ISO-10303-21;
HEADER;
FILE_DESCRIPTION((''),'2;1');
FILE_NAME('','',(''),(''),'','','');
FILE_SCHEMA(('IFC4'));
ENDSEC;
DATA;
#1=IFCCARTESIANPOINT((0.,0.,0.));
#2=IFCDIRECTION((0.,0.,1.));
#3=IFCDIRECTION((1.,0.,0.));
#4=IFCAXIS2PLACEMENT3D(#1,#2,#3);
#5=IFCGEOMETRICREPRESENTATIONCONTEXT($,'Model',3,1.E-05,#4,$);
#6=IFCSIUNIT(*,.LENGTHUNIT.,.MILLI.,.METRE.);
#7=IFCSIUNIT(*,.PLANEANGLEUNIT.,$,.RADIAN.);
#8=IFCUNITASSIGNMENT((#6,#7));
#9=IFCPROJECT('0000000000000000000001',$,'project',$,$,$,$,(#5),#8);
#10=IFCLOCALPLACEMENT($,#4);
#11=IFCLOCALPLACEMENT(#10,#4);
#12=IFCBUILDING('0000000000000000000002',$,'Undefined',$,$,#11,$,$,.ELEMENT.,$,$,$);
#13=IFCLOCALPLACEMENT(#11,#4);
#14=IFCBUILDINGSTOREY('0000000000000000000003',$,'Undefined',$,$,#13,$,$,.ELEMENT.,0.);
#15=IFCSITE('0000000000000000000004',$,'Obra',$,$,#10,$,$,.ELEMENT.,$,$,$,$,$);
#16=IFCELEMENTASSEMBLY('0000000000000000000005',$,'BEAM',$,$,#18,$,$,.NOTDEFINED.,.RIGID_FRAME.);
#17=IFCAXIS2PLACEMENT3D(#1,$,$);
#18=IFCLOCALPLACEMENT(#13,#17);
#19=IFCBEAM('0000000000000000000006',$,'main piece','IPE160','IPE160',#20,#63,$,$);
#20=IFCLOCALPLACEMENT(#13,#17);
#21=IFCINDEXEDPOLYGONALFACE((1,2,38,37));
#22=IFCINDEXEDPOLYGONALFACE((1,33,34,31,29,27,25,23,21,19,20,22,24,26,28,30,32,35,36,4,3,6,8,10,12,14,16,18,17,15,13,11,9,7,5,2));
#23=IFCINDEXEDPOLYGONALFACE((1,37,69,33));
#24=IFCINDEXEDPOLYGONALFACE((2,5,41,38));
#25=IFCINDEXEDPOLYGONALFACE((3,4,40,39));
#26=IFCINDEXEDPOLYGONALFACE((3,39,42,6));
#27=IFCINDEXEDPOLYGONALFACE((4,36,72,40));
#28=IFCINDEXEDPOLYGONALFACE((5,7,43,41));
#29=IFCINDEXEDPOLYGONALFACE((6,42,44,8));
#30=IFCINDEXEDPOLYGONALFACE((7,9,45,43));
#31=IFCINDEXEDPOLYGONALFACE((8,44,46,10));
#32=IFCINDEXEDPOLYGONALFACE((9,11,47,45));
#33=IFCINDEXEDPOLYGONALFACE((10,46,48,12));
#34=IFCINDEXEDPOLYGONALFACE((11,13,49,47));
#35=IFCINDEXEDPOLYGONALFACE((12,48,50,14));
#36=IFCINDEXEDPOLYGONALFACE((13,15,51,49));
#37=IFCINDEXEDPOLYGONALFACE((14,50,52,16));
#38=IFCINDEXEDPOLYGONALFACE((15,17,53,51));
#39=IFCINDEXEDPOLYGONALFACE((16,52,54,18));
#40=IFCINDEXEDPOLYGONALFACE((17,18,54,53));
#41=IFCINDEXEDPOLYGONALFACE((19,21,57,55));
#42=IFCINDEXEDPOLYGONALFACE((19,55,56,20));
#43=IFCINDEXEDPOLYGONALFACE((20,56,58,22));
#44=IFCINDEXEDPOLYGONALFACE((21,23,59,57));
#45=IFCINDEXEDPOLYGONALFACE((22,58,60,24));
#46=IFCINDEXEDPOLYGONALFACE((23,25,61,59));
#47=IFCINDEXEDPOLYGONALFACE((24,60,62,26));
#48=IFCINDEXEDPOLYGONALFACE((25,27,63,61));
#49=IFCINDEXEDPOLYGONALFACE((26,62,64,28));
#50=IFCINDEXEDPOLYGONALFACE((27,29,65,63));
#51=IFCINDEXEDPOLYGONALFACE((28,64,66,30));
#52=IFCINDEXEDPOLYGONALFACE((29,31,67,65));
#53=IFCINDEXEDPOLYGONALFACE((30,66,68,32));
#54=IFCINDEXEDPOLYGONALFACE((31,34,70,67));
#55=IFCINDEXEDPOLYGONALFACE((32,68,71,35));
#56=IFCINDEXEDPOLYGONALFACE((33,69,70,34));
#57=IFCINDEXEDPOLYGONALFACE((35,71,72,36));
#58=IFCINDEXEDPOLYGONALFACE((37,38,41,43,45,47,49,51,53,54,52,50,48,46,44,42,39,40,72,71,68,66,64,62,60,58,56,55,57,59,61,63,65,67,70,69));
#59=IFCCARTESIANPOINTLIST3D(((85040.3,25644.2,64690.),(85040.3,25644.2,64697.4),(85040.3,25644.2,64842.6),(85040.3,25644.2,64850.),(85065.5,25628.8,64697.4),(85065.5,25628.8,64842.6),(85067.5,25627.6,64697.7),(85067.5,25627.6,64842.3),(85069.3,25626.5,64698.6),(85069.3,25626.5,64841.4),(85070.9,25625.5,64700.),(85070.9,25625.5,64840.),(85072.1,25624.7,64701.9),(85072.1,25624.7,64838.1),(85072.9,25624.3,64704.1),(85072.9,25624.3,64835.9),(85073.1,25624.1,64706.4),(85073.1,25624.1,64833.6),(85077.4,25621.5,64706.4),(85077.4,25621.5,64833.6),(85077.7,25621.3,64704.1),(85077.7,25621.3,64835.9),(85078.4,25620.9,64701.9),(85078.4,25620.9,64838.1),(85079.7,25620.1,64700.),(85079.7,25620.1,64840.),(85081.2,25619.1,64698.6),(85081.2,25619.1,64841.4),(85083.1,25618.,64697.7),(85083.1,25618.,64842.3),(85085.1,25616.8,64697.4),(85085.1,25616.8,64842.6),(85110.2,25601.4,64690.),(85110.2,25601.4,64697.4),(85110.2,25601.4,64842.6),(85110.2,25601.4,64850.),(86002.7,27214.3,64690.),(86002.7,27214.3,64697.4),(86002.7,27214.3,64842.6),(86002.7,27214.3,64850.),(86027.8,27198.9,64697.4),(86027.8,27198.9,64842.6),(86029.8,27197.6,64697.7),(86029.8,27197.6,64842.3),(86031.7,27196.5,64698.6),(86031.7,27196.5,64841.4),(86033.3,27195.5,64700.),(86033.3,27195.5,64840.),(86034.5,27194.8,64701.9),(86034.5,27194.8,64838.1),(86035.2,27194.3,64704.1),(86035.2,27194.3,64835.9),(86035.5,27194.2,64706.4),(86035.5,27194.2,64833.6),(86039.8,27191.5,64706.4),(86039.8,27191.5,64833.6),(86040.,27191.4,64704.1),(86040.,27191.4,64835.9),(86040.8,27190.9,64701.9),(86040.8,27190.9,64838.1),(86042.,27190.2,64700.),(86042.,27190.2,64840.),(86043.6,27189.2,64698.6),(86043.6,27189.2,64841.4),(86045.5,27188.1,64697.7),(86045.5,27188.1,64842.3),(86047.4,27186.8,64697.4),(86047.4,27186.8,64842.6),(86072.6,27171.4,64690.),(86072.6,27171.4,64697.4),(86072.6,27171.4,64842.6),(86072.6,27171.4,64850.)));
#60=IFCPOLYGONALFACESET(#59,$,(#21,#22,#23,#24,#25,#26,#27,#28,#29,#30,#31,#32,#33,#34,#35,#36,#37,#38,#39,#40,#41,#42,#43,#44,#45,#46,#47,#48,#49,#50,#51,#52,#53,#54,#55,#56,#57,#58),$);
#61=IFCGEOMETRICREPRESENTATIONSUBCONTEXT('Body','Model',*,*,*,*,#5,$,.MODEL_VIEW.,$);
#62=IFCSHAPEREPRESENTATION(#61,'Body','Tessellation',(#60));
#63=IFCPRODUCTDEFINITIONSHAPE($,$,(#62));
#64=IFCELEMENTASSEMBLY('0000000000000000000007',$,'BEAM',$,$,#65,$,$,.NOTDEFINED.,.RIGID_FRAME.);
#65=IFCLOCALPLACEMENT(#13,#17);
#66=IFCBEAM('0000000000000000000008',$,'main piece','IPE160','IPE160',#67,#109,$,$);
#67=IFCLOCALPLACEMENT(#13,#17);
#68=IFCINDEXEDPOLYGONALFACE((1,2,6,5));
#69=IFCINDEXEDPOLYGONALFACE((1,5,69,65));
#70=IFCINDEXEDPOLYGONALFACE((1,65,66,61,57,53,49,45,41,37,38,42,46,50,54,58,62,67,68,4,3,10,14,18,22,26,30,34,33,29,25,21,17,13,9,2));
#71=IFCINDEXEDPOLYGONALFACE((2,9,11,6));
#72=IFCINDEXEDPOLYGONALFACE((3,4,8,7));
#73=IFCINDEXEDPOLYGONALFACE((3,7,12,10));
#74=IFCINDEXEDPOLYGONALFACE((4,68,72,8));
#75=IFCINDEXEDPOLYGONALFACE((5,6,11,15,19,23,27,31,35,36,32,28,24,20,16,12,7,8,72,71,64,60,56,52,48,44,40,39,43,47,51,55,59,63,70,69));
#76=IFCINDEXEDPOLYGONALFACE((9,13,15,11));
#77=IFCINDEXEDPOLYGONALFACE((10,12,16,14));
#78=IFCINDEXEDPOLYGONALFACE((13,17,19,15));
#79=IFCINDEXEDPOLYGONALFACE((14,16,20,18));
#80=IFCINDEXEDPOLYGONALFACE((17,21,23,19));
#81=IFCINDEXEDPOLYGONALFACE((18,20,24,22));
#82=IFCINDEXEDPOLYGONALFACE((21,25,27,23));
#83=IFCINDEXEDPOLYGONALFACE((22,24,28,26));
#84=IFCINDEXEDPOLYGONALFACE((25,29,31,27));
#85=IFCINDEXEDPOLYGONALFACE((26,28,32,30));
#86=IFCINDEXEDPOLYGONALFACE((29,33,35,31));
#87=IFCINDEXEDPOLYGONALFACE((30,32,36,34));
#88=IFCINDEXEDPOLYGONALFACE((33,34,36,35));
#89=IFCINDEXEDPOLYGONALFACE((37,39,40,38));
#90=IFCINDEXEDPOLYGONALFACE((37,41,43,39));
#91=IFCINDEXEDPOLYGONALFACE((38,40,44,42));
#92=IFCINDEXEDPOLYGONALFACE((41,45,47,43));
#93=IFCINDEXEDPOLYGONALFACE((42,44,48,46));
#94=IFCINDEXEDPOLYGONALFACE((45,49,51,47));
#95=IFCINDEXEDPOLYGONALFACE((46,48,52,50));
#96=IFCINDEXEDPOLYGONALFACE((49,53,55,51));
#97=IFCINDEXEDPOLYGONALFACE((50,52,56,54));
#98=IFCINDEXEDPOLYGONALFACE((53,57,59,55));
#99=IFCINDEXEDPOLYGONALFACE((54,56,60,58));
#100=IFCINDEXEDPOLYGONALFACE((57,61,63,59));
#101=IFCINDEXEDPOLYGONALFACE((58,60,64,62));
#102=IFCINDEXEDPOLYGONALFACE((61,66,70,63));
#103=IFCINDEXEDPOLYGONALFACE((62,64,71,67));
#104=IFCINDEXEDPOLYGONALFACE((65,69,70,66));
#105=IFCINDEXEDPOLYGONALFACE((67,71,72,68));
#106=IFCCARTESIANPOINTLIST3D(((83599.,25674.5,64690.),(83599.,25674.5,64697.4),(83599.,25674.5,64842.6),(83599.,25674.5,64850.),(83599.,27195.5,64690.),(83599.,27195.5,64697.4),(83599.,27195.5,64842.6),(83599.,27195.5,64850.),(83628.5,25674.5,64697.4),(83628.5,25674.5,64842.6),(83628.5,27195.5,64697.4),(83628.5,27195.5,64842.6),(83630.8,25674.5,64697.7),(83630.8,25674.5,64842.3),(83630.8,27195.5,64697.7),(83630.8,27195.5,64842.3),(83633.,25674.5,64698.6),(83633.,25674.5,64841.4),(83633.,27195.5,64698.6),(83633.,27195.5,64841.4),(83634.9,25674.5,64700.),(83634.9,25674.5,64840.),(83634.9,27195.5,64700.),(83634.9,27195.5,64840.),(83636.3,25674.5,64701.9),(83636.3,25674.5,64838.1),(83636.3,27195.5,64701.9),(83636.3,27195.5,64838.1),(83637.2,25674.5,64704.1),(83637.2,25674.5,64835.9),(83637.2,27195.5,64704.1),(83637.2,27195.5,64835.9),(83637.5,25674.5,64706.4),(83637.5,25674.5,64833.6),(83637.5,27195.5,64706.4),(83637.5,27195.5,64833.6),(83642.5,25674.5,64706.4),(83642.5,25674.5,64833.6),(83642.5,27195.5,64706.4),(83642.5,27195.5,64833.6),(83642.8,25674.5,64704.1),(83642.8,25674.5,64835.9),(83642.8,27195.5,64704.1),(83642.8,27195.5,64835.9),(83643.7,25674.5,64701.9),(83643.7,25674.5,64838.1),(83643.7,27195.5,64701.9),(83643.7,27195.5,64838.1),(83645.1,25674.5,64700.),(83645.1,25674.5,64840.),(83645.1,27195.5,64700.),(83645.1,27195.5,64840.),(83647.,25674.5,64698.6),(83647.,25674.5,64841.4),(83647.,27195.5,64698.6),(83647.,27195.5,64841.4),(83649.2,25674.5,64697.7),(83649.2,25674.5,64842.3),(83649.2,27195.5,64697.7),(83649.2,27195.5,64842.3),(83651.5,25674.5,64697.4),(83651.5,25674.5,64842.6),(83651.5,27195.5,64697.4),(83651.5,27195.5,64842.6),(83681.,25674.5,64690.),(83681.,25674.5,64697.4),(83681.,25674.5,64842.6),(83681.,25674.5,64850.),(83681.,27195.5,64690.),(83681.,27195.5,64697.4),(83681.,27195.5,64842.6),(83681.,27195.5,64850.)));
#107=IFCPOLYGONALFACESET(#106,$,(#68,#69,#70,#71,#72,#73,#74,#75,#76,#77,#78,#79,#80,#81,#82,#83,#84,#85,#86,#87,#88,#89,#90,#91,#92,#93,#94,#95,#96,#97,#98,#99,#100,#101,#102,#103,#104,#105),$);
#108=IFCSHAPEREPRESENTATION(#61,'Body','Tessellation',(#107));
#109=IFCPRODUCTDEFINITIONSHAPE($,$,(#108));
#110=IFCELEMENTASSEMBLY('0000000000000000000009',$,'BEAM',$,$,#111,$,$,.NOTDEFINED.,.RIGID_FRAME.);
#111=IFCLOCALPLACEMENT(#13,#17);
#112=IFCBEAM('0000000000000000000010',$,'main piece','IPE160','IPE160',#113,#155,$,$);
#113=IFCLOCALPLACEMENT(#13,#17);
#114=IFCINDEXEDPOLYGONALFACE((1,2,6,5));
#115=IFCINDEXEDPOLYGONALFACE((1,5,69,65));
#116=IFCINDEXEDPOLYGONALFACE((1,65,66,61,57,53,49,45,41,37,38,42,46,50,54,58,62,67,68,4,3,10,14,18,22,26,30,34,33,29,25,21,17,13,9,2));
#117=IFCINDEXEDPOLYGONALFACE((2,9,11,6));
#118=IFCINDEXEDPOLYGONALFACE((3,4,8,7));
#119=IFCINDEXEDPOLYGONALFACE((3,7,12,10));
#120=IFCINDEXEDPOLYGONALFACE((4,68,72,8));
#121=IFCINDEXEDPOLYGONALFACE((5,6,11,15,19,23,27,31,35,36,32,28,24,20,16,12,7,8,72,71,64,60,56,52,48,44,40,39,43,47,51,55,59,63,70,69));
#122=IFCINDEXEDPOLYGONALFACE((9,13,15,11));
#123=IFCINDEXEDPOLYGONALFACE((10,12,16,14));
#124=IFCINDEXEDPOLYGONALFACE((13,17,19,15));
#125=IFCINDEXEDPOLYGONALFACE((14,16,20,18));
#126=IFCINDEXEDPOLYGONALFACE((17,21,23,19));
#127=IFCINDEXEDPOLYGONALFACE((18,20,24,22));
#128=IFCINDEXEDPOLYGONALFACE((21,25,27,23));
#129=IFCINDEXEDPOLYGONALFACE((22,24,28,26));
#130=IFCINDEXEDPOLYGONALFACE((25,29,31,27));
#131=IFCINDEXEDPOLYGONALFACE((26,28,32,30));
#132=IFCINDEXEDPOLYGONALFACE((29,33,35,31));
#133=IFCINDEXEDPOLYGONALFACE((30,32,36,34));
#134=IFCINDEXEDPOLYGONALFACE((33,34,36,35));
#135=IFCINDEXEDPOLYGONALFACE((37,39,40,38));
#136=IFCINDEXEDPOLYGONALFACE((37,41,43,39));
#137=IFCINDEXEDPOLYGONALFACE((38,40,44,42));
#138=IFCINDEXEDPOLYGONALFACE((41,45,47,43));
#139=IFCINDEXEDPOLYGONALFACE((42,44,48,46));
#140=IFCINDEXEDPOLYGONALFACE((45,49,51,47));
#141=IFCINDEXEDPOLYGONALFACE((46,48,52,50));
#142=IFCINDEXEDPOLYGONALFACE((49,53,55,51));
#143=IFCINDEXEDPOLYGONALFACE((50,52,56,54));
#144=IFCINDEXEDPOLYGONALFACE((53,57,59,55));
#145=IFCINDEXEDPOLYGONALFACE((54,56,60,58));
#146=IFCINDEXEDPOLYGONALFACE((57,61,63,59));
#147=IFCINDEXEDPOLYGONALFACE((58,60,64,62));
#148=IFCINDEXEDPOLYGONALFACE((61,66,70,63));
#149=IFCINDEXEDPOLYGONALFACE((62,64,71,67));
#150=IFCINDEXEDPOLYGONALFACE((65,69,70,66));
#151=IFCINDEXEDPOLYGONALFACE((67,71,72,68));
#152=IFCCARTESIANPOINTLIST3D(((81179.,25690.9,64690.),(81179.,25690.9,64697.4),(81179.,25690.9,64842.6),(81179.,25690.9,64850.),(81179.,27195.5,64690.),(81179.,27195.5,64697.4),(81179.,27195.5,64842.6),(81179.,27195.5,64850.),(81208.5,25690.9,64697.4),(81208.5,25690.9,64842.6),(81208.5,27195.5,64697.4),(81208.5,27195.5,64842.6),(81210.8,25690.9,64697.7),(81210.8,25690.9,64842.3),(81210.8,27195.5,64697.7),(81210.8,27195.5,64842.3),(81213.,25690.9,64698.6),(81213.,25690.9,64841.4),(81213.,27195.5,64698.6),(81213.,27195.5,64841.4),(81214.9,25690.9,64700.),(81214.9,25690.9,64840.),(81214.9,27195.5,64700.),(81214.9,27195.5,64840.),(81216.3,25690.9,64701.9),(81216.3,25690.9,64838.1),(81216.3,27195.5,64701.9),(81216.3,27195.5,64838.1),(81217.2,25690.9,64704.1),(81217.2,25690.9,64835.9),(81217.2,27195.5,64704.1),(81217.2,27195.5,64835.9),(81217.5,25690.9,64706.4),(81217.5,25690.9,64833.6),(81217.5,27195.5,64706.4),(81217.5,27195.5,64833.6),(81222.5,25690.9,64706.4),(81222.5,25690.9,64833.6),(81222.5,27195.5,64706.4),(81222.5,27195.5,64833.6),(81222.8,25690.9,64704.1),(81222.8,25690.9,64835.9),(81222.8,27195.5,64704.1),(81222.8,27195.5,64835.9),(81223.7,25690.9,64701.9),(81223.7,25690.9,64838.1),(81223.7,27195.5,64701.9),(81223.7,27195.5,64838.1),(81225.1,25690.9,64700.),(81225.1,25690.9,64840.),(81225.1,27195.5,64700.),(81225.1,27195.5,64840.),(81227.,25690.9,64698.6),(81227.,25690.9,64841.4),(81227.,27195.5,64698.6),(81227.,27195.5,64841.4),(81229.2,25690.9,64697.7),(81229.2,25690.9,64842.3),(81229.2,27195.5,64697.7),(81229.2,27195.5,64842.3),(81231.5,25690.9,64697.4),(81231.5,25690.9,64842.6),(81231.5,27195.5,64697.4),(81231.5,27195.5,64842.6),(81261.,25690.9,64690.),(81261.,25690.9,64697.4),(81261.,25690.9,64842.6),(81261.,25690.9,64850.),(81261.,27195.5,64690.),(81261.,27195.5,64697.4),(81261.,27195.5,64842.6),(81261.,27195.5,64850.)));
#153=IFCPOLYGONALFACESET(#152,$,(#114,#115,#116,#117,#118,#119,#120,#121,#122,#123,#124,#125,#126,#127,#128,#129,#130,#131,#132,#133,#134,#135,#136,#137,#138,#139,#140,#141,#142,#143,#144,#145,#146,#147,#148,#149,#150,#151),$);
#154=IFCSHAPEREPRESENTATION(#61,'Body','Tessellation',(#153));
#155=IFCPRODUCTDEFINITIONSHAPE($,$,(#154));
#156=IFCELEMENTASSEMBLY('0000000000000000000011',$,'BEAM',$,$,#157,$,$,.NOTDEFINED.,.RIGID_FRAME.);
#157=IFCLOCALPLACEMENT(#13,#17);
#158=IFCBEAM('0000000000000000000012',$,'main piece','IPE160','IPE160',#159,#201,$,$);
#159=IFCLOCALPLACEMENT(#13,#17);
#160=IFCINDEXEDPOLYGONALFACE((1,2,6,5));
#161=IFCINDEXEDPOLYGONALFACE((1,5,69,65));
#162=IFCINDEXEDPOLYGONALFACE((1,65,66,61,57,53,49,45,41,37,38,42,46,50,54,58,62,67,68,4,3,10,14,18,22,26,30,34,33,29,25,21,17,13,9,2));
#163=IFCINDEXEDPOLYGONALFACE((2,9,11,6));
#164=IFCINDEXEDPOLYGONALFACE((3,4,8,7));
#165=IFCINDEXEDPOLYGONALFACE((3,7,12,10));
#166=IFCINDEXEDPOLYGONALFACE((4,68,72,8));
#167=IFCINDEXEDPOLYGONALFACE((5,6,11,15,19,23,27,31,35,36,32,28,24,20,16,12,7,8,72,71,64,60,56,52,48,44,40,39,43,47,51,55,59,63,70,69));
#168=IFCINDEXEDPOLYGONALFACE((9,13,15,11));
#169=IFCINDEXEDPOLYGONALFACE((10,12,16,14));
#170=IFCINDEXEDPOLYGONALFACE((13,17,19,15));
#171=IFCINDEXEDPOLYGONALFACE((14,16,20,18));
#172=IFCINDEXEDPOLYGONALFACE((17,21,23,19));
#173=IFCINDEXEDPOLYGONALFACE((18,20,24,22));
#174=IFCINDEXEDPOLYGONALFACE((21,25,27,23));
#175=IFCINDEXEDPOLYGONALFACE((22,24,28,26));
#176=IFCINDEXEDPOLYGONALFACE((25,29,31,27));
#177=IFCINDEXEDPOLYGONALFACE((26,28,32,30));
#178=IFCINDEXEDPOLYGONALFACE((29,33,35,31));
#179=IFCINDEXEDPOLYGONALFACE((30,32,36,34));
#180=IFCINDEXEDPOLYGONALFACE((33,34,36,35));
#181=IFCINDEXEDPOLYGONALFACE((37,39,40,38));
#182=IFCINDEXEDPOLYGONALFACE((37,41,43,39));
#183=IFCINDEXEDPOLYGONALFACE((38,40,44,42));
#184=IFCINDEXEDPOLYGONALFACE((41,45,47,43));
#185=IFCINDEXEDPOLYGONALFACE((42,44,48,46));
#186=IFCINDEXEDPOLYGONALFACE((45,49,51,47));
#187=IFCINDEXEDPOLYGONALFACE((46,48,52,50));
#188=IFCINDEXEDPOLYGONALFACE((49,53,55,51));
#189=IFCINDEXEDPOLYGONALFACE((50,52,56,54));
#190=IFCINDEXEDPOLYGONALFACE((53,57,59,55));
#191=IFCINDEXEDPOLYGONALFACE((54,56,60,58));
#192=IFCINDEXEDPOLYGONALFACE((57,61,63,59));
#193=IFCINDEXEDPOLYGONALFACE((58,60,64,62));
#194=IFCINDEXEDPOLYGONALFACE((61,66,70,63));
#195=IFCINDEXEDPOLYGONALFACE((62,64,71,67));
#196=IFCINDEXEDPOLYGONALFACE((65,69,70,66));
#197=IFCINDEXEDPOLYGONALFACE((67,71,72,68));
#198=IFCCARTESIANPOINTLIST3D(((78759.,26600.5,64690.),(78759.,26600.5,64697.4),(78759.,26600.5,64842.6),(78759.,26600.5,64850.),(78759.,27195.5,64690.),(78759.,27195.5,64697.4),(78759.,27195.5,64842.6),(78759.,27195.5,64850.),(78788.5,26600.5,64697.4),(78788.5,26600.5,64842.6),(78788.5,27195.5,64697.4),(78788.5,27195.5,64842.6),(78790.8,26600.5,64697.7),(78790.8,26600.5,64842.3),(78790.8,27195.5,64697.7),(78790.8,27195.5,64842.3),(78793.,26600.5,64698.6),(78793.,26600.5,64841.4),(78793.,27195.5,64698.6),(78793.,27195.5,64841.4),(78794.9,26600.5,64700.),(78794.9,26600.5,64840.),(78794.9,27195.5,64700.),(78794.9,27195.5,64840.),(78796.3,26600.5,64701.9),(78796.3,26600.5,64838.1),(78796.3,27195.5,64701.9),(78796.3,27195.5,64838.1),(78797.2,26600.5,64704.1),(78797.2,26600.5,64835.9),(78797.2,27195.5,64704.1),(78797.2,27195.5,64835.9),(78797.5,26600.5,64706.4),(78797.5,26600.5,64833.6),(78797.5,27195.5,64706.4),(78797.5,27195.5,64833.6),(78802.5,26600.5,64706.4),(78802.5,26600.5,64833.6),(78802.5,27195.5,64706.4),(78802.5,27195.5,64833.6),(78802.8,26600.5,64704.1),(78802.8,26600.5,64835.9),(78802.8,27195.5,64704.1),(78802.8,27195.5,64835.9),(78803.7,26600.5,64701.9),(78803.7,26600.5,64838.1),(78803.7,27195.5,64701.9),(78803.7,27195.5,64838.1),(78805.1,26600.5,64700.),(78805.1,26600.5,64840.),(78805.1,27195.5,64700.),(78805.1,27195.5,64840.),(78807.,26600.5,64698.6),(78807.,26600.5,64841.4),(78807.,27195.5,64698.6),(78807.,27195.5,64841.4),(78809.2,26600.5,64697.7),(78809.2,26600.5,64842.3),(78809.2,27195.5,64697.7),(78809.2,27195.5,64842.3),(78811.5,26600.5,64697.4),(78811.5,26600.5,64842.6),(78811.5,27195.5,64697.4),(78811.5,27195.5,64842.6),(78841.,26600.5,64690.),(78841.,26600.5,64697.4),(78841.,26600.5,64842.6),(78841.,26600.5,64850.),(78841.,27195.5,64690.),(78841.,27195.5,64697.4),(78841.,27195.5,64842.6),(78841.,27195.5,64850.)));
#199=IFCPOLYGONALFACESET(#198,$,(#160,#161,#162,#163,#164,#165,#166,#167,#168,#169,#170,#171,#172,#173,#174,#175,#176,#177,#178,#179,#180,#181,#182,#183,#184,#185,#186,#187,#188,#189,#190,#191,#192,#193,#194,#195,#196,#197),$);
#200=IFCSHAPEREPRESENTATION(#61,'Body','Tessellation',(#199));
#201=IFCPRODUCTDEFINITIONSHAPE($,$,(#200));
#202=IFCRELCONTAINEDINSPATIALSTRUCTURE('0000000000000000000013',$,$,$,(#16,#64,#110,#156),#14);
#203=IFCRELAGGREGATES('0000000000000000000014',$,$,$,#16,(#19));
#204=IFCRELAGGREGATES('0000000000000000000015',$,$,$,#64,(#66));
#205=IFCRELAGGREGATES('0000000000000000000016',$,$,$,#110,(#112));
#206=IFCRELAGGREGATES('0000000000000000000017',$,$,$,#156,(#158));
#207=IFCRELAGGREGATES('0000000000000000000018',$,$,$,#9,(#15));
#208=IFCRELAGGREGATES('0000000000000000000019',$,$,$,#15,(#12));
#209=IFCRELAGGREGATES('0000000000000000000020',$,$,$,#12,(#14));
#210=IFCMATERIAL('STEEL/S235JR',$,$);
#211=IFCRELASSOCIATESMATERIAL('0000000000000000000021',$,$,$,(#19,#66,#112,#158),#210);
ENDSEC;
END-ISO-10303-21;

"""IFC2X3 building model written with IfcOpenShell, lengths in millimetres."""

from ifc_helpers import new_model, si_unit, frame, origin_with_axes, origin_2d_with_axis, place, context, subcontext, project, spatial, i_section, extrude, material, element, aggregate, save


model = new_model("IFC2X3")

# Units and contexts
model_context = context("Model", 3, precision=1e-05, world=origin_with_axes())
body_context = subcontext(model_context, "Body", "Model", "MODEL_VIEW")
ifc_project = project(units=[si_unit("LENGTHUNIT", "METRE", prefix="MILLI"), si_unit("PLANEANGLEUNIT", "RADIAN")], contexts=[model_context])

# Site, building, storey
site_placement = place(None, origin_with_axes())
site = spatial("IfcSite", under=ifc_project, at=site_placement, Name="Obra", CompositionType="ELEMENT")
building_placement = place(site_placement, origin_with_axes())
building = spatial("IfcBuilding", under=site, at=building_placement, Name="Undefined", CompositionType="ELEMENT")
storey_placement = place(building_placement, origin_with_axes())
storey = spatial("IfcBuildingStorey", under=building, at=storey_placement, Name="Undefined", CompositionType="ELEMENT", Elevation=0.0)

# Element assemblies, beams
assembly_1_placement = place(storey_placement, origin_with_axes())
assembly_1 = element("IfcElementAssembly", 1, at=assembly_1_placement, inside=storey, Name="BEAM", AssemblyPlace="NOTDEFINED", PredefinedType="RIGID_FRAME")
ifc_material_1 = material(Name="STEEL/S235JR")
beam_1_placement = place(assembly_1_placement, frame((85075.3, 25622.8, 64770.0), z_axis=(0.0, 0.0, 1.0), x_axis=(0.522594, 0.852582, 0.0)))
beam_1 = element("IfcBeam", 2, at=beam_1_placement, material=ifc_material_1, Name="main piece", Description="IPE160", ObjectType="IPE160", context=body_context, shape_type="SweptSolid", body=[
    extrude(i_section(OverallWidth=82.0, OverallDepth=160.0, WebThickness=5.0, FlangeThickness=7.4, FilletRadius=9.0, at=origin_2d_with_axis()), frame((1841.5, 0.0, 0.0), z_axis=(-1.0, 0.0, 0.0), x_axis=(0.0, -1.0, 0.0)), (0.0, 0.0, 1.0), 1841.5),
])
aggregate(assembly_1, [beam_1])
assembly_2_placement = place(storey_placement, origin_with_axes())
assembly_2 = element("IfcElementAssembly", 3, at=assembly_2_placement, inside=storey, Name="BEAM", AssemblyPlace="NOTDEFINED", PredefinedType="RIGID_FRAME")
beam_2_placement = place(assembly_2_placement, frame((83640.0, 25674.5, 64770.0), z_axis=(0.0, 0.0, 1.0), x_axis=(0.000003, 1.0, 0.0)))
beam_2 = element("IfcBeam", 4, at=beam_2_placement, material=ifc_material_1, Name="main piece", Description="IPE160", ObjectType="IPE160", context=body_context, shape_type="SweptSolid", body=[
    extrude(i_section(OverallWidth=82.0, OverallDepth=160.0, WebThickness=5.0, FlangeThickness=7.4, FilletRadius=9.0, at=origin_2d_with_axis()), frame((1521.0, 0.0, 0.0), z_axis=(-1.0, 0.0, 0.0), x_axis=(0.0, -1.0, 0.0)), (0.0, 0.0, 1.0), 1521.0),
])
aggregate(assembly_2, [beam_2])
assembly_3_placement = place(storey_placement, origin_with_axes())
assembly_3 = element("IfcElementAssembly", 5, at=assembly_3_placement, inside=storey, Name="BEAM", AssemblyPlace="NOTDEFINED", PredefinedType="RIGID_FRAME")
beam_3_placement = place(assembly_3_placement, frame((81220.0, 25690.9, 64770.0), z_axis=(0.0, 0.0, 1.0), x_axis=(-0.000002, 1.0, 0.0)))
beam_3 = element("IfcBeam", 6, at=beam_3_placement, material=ifc_material_1, Name="main piece", Description="IPE160", ObjectType="IPE160", context=body_context, shape_type="SweptSolid", body=[
    extrude(i_section(OverallWidth=82.0, OverallDepth=160.0, WebThickness=5.0, FlangeThickness=7.4, FilletRadius=9.0, at=origin_2d_with_axis()), frame((1504.6, 0.0, 0.0), z_axis=(-1.0, 0.0, 0.0), x_axis=(0.0, -1.0, 0.0)), (0.0, 0.0, 1.0), 1504.6),
])
aggregate(assembly_3, [beam_3])
assembly_4_placement = place(storey_placement, origin_with_axes())
assembly_4 = element("IfcElementAssembly", 7, at=assembly_4_placement, inside=storey, Name="BEAM", AssemblyPlace="NOTDEFINED", PredefinedType="RIGID_FRAME")
beam_4_placement = place(assembly_4_placement, frame((78800.0, 26600.5, 64770.0), z_axis=(0.0, 0.0, 1.0), x_axis=(0.0, 1.0, 0.0)))
beam_4 = element("IfcBeam", 8, at=beam_4_placement, material=ifc_material_1, Name="main piece", Description="IPE160", ObjectType="IPE160", context=body_context, shape_type="SweptSolid", body=[
    extrude(i_section(OverallWidth=82.0, OverallDepth=160.0, WebThickness=5.0, FlangeThickness=7.4, FilletRadius=9.0, at=origin_2d_with_axis()), frame((595.1, 0.0, 0.0), z_axis=(-1.0, 0.0, 0.0), x_axis=(0.0, -1.0, 0.0)), (0.0, 0.0, 1.0), 595.0),
])
aggregate(assembly_4, [beam_4])

save(model, "model.ifc")
